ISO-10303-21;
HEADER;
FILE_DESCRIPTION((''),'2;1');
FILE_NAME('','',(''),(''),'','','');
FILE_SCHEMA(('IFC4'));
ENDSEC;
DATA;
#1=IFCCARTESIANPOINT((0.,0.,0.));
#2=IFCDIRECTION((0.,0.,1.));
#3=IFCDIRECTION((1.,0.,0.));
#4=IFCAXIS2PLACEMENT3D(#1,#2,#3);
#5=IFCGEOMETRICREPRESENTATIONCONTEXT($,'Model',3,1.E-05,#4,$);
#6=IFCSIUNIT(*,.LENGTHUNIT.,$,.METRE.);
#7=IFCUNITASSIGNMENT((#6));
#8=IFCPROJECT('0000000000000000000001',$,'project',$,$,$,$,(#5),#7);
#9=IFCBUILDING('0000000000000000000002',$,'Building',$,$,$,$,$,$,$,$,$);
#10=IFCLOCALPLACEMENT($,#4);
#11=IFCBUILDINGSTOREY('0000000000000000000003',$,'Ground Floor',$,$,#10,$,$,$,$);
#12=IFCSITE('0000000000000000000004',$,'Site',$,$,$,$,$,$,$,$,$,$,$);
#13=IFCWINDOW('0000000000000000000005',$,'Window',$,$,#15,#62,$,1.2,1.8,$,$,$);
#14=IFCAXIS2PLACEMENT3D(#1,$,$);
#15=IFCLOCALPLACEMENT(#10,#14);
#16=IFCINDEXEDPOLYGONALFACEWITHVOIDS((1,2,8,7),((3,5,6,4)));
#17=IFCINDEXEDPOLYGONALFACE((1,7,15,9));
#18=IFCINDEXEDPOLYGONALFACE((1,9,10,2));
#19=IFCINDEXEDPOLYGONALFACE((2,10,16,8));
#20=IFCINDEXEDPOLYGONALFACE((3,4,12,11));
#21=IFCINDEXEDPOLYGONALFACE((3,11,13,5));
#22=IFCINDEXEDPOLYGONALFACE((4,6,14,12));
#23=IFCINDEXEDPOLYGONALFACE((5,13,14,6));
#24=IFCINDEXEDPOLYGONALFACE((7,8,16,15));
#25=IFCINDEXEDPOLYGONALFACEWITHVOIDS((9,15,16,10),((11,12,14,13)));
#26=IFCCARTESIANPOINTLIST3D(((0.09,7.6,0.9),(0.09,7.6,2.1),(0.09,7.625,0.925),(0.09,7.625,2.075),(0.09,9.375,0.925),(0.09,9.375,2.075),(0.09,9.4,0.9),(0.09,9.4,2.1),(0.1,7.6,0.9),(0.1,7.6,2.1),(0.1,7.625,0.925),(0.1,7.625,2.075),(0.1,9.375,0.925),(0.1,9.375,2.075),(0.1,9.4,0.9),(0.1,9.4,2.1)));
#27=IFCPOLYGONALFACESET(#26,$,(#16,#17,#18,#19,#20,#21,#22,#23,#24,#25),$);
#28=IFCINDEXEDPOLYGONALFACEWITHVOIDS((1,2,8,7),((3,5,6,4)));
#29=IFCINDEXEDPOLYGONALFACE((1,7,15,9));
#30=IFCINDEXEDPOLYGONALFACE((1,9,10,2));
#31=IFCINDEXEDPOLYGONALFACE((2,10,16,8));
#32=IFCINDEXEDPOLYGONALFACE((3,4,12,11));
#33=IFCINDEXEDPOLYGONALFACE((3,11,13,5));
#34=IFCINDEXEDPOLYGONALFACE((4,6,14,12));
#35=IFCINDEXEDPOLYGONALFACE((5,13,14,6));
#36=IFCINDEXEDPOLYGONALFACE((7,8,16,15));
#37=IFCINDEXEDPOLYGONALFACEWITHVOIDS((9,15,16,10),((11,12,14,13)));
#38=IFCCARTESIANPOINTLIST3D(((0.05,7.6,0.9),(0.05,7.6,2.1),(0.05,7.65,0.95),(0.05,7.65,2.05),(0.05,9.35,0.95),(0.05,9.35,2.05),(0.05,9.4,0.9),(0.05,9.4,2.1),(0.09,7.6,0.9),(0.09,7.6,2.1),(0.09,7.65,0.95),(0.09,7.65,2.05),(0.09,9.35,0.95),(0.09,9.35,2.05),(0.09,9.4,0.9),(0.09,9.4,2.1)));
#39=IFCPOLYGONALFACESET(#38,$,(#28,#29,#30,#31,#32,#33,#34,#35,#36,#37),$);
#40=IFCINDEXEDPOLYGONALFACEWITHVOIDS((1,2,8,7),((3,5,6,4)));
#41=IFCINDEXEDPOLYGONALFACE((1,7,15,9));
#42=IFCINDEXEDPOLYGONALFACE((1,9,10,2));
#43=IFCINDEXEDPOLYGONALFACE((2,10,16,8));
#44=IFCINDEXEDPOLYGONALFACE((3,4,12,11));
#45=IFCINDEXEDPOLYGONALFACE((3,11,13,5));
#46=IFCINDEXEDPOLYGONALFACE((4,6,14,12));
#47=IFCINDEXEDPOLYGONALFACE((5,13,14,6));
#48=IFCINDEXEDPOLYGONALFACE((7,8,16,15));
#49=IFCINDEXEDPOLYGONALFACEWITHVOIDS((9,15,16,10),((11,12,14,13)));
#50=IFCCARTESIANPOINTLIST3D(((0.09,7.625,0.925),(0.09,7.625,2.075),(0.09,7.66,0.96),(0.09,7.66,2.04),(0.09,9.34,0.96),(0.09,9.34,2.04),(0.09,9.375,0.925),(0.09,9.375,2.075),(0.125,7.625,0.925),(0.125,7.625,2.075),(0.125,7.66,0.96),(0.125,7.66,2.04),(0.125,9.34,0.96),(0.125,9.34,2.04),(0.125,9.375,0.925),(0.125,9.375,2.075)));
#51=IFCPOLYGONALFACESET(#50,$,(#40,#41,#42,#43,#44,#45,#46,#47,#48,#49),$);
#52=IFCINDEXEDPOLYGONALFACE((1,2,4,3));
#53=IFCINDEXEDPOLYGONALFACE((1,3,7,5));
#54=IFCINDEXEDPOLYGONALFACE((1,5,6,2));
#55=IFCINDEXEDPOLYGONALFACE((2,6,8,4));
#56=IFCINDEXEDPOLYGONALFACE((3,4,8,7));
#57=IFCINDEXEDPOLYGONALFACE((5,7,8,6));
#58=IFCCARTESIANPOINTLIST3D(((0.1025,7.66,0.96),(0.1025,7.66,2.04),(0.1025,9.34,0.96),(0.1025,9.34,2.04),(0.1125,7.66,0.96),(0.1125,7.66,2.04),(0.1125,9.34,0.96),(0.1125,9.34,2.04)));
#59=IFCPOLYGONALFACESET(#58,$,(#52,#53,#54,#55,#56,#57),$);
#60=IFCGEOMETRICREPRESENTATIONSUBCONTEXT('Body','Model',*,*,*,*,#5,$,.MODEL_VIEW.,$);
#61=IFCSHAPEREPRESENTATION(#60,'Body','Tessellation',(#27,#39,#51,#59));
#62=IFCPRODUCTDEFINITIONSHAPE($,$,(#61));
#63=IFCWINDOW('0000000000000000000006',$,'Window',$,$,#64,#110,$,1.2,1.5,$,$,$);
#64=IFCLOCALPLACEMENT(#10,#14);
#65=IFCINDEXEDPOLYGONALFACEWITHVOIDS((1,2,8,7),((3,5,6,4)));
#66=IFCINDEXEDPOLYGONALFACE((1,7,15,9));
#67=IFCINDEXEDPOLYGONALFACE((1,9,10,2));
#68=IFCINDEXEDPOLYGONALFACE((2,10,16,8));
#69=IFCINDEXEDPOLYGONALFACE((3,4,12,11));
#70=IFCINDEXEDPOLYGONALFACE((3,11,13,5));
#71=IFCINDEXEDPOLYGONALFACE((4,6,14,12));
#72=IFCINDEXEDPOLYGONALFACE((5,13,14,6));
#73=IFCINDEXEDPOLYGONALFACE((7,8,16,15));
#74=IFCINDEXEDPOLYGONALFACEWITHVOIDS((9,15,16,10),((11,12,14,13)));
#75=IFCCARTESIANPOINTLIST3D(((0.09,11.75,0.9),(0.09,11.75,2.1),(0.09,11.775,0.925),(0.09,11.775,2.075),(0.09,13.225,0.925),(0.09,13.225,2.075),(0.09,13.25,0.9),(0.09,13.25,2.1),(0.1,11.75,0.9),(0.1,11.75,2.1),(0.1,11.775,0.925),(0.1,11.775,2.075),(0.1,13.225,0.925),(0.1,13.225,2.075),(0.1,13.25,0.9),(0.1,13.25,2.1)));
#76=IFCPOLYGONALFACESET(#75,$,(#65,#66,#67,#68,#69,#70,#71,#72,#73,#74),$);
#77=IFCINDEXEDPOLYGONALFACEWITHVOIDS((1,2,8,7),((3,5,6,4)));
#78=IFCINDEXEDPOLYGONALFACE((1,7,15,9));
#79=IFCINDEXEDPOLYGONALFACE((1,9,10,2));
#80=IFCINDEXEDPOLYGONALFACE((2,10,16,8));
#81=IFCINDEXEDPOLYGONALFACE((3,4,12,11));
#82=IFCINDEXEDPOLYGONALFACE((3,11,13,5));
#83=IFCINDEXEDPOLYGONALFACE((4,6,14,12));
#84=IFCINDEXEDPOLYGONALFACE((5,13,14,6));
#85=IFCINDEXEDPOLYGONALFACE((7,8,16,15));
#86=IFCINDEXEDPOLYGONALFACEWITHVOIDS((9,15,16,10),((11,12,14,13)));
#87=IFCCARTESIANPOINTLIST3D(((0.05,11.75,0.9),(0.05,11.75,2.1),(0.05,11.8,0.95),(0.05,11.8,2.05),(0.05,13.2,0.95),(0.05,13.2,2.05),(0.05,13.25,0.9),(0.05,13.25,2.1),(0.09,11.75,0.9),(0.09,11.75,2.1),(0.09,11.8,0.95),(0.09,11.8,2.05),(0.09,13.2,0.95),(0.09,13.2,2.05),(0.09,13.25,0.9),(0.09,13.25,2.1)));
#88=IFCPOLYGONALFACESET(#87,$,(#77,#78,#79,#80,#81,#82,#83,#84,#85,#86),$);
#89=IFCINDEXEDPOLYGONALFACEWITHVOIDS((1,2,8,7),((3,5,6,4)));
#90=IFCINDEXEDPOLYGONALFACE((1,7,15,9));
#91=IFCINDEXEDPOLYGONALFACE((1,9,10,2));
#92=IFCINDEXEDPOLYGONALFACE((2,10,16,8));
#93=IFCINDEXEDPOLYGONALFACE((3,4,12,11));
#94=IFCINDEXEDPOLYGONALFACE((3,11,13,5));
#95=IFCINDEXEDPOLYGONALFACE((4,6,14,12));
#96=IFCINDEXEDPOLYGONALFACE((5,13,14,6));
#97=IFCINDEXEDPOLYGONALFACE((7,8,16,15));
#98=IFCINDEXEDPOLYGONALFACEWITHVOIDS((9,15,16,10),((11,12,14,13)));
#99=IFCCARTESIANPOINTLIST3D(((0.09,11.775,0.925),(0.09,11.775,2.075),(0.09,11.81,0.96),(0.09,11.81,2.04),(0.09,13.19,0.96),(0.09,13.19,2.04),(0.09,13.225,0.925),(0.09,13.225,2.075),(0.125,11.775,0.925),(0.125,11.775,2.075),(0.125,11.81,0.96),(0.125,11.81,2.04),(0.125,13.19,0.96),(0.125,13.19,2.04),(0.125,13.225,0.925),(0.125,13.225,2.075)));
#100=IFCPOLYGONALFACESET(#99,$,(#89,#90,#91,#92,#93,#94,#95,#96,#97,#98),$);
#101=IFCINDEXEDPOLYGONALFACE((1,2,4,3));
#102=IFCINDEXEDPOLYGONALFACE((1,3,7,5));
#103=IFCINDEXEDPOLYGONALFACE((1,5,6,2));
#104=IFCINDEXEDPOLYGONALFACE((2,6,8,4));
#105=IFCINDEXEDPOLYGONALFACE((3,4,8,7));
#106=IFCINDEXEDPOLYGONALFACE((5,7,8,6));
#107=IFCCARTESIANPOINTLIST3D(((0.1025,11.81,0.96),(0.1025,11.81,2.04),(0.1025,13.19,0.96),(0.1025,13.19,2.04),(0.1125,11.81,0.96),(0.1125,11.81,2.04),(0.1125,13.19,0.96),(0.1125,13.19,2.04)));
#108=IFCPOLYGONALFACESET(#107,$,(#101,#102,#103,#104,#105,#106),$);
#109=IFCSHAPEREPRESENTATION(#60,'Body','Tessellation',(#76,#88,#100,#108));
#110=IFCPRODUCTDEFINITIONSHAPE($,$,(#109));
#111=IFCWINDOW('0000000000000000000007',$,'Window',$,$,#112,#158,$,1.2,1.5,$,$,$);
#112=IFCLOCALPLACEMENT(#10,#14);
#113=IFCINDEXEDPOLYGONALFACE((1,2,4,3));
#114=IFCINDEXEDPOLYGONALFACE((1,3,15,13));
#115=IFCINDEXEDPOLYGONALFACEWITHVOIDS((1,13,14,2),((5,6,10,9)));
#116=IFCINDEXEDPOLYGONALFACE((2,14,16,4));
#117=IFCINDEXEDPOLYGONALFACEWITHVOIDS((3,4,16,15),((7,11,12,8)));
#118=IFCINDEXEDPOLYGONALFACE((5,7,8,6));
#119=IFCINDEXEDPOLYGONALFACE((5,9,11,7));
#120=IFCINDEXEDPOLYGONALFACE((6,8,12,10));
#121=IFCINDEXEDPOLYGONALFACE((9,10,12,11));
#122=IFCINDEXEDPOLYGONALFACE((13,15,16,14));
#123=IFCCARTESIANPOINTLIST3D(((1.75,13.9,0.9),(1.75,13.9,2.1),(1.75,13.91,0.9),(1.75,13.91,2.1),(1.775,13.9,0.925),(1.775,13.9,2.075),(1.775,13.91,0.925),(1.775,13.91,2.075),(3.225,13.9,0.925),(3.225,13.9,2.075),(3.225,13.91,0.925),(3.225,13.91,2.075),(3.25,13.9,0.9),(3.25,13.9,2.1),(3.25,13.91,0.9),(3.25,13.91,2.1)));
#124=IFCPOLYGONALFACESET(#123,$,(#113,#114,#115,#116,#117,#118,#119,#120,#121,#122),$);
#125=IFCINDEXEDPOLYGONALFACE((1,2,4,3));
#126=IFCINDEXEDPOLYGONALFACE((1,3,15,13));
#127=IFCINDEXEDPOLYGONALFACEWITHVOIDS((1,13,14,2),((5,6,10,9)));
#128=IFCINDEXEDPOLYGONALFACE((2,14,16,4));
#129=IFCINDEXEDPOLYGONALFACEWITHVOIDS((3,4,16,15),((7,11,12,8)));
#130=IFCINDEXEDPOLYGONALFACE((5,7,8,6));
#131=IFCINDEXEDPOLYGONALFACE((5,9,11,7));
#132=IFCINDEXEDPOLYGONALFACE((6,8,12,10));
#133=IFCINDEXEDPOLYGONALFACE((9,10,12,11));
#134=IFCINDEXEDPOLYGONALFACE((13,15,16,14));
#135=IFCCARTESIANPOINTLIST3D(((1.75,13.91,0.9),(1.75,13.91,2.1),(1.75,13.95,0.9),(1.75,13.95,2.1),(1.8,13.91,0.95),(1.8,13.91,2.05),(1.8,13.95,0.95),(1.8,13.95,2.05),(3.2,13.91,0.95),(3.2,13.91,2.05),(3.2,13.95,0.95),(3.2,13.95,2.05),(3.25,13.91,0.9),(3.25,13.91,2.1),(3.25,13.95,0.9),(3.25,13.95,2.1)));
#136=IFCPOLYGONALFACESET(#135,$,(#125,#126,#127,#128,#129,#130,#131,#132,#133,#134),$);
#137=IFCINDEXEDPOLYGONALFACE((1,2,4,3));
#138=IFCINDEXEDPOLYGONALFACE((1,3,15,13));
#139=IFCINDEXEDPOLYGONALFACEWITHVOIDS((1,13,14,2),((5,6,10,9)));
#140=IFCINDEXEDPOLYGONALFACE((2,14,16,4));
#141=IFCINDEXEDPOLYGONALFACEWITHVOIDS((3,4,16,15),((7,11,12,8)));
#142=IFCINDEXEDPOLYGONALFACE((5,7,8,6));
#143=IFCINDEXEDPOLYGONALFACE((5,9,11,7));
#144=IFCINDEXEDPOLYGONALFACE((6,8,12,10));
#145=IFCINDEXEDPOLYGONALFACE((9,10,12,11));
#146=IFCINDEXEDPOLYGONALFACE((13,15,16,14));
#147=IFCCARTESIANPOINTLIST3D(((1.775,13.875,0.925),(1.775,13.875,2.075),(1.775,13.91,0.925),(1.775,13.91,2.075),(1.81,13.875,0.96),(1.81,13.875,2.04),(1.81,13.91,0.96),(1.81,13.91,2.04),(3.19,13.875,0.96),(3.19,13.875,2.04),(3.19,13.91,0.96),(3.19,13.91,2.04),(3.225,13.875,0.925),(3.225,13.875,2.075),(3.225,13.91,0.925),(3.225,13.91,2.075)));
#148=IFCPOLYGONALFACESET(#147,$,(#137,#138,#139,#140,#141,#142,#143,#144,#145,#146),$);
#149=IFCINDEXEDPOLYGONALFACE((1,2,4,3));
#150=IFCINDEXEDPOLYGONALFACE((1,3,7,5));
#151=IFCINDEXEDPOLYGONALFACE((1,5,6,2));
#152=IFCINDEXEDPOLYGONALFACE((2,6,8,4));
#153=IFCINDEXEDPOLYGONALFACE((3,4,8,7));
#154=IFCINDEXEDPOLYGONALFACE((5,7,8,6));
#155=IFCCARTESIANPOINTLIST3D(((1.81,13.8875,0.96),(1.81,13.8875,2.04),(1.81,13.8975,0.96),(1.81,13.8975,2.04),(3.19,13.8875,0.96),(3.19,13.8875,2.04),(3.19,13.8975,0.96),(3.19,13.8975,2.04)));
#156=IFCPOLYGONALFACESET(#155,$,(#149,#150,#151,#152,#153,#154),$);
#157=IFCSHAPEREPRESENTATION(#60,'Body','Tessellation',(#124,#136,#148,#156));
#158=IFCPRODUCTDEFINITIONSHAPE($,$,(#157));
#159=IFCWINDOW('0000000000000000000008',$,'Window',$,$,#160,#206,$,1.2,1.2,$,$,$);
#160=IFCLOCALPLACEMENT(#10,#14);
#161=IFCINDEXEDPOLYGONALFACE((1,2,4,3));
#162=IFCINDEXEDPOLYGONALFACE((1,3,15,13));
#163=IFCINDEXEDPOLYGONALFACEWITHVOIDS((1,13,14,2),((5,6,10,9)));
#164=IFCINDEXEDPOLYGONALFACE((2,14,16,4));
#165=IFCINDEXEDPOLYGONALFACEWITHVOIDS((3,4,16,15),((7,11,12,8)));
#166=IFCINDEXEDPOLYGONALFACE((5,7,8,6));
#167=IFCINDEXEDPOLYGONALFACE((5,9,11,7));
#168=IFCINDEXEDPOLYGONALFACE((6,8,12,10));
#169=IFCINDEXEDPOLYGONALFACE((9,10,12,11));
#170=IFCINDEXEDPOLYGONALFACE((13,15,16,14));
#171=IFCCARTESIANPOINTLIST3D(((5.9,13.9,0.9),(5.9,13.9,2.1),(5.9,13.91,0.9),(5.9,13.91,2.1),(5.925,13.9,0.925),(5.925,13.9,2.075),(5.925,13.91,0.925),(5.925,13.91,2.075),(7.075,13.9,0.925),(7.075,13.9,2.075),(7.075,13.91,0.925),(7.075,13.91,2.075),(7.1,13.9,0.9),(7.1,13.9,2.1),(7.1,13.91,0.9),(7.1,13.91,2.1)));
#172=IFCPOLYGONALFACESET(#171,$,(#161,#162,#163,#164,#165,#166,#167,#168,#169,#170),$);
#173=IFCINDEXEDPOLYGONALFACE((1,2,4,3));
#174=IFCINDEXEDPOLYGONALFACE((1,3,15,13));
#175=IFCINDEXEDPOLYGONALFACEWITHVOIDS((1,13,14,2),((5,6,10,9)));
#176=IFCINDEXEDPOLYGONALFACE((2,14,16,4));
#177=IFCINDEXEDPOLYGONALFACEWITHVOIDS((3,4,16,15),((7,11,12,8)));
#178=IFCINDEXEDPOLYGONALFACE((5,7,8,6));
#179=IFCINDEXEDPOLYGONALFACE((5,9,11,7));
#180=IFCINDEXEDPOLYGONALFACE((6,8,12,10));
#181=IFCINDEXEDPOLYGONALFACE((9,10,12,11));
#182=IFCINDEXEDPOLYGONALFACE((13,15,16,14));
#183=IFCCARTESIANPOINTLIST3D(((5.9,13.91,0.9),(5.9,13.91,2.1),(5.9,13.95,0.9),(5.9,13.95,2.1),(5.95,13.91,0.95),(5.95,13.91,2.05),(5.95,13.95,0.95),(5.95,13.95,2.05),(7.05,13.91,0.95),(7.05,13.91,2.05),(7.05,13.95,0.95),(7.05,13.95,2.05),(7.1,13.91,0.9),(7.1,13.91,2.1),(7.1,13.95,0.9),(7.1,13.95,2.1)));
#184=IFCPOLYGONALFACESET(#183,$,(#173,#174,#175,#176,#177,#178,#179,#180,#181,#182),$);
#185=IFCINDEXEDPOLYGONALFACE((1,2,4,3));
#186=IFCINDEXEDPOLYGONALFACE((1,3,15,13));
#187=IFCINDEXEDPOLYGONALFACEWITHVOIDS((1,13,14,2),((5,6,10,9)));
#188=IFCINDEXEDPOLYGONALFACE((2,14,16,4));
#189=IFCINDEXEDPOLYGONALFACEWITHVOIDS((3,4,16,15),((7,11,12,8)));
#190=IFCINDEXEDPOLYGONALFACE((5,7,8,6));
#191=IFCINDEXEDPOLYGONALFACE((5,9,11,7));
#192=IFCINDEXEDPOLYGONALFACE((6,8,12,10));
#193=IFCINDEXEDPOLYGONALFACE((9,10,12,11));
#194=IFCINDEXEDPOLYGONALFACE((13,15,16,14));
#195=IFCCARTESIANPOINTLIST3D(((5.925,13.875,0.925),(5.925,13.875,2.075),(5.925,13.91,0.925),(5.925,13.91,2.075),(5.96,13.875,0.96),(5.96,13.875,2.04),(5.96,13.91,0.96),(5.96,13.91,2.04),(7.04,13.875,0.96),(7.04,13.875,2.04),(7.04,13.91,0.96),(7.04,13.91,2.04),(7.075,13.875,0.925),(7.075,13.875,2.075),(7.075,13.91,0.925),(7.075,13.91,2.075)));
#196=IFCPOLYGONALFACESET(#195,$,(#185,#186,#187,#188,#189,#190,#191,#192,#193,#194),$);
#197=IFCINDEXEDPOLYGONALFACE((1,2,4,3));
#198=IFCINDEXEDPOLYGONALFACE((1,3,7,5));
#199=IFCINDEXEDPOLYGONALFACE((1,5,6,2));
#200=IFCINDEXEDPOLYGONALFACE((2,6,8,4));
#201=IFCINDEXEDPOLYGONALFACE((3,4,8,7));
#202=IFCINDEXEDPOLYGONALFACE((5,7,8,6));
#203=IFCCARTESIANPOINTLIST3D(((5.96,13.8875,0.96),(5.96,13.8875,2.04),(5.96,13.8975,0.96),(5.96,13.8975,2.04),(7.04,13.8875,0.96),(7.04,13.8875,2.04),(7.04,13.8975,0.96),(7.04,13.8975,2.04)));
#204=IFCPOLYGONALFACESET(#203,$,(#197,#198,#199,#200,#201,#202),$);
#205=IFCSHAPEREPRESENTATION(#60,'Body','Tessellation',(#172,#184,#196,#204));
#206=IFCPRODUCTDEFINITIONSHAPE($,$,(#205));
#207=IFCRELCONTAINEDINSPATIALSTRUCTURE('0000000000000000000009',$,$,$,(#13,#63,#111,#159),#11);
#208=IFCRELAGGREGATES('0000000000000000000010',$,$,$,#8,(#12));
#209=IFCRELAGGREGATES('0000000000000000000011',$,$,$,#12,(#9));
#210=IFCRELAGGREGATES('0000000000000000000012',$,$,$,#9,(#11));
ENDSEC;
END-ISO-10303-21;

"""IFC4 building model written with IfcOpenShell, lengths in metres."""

from ifc_helpers import new_model, si_unit, frame, origin_with_axes, place, context, subcontext, project, spatial, line, indexed_curve, outline, extrude, element, save


model = new_model("IFC4")

# Units and contexts
model_context = context("Model", 3, precision=1e-05, world=origin_with_axes())
body_context = subcontext(model_context, "Body", "Model", "MODEL_VIEW")
ifc_project = project(units=[si_unit("LENGTHUNIT", "METRE")], contexts=[model_context])

# Site, building, storey
site = spatial("IfcSite", under=ifc_project, Name="Site")
building = spatial("IfcBuilding", under=site, Name="Building")
storey_placement = place(None, origin_with_axes())
storey = spatial("IfcBuildingStorey", under=building, at=storey_placement, Name="Ground Floor")

# Windows
window_1_placement = place(storey_placement, frame((0.0, 9.4, 0.9), z_axis=(0.0, 0.0, 1.0), x_axis=(0.0, -1.0, 0.0)))
element("IfcWindow", 1, at=window_1_placement, inside=storey, Name="Window", OverallHeight=1.2, OverallWidth=1.8, context=body_context, shape_type="SweptSolid", body=[
    extrude(outline(indexed_curve([(0.0, 0.0), (1.8, 0.0), (1.8, 1.2), (0.0, 1.2)], segments=[line(1, 2, 3, 4, 1)]), holes=[indexed_curve([(0.025, 0.025), (1.775, 0.025), (1.775, 1.175), (0.025, 1.175)], segments=[line(1, 2, 3, 4, 1)])]), frame((0.0, 0.09, 0.0), z_axis=(0.0, -1.0, 0.0), x_axis=(1.0, 0.0, 0.0)), (0.0, 0.0, -1.0), 0.01),
    extrude(outline(indexed_curve([(0.0, 0.0), (1.8, 0.0), (1.8, 1.2), (0.0, 1.2)], segments=[line(1, 2, 3, 4, 1)]), holes=[indexed_curve([(0.05, 0.05), (1.75, 0.05), (1.75, 1.15), (0.05, 1.15)], segments=[line(1, 2, 3, 4, 1)])]), frame((0.0, 0.05, 0.0), z_axis=(0.0, -1.0, 0.0), x_axis=(1.0, 0.0, 0.0)), (0.0, 0.0, -1.0), 0.04),
    extrude(outline(indexed_curve([(0.0, 0.0), (1.75, 0.0), (1.75, 1.15), (0.0, 1.15)], segments=[line(1, 2, 3, 4, 1)]), holes=[indexed_curve([(0.035, 0.035), (1.715, 0.035), (1.715, 1.115), (0.035, 1.115)], segments=[line(1, 2, 3, 4, 1)])]), frame((0.025, 0.09, 0.025), z_axis=(0.0, -1.0, 0.0), x_axis=(1.0, 0.0, 0.0)), (0.0, 0.0, -1.0), 0.035),
    extrude(outline(indexed_curve([(0.035, 0.035), (1.715, 0.035), (1.715, 1.115), (0.035, 1.115)], segments=[line(1, 2, 3, 4, 1)])), frame((0.025, 0.1025, 0.025), z_axis=(0.0, -1.0, 0.0), x_axis=(1.0, 0.0, 0.0)), (0.0, 0.0, -1.0), 0.01),
])
for number, where, z_axis, x_axis, name in (
    (2, (0.0, 13.25, 0.9), (0.0, 0.0, 1.0), (0.0, -1.0, 0.0), "Window"),
    (3, (3.25, 14.0, 0.9), (0.0, 0.0, 1.0), (-1.0, 0.0, 0.0), "Window"),
):
    element("IfcWindow", number, at=place(storey_placement, frame(where, z_axis=z_axis, x_axis=x_axis)), inside=storey, Name=name, OverallHeight=1.2, OverallWidth=1.5, context=body_context, shape_type="SweptSolid", body=[
        extrude(outline(indexed_curve([(0.0, 0.0), (1.5, 0.0), (1.5, 1.2), (0.0, 1.2)], segments=[line(1, 2, 3, 4, 1)]), holes=[indexed_curve([(0.025, 0.025), (1.475, 0.025), (1.475, 1.175), (0.025, 1.175)], segments=[line(1, 2, 3, 4, 1)])]), frame((0.0, 0.09, 0.0), z_axis=(0.0, -1.0, 0.0), x_axis=(1.0, 0.0, 0.0)), (0.0, 0.0, -1.0), 0.01),
        extrude(outline(indexed_curve([(0.0, 0.0), (1.5, 0.0), (1.5, 1.2), (0.0, 1.2)], segments=[line(1, 2, 3, 4, 1)]), holes=[indexed_curve([(0.05, 0.05), (1.45, 0.05), (1.45, 1.15), (0.05, 1.15)], segments=[line(1, 2, 3, 4, 1)])]), frame((0.0, 0.05, 0.0), z_axis=(0.0, -1.0, 0.0), x_axis=(1.0, 0.0, 0.0)), (0.0, 0.0, -1.0), 0.04),
        extrude(outline(indexed_curve([(0.0, 0.0), (1.45, 0.0), (1.45, 1.15), (0.0, 1.15)], segments=[line(1, 2, 3, 4, 1)]), holes=[indexed_curve([(0.035, 0.035), (1.415, 0.035), (1.415, 1.115), (0.035, 1.115)], segments=[line(1, 2, 3, 4, 1)])]), frame((0.025, 0.09, 0.025), z_axis=(0.0, -1.0, 0.0), x_axis=(1.0, 0.0, 0.0)), (0.0, 0.0, -1.0), 0.035),
        extrude(outline(indexed_curve([(0.035, 0.035), (1.415, 0.035), (1.415, 1.115), (0.035, 1.115)], segments=[line(1, 2, 3, 4, 1)])), frame((0.025, 0.1025, 0.025), z_axis=(0.0, -1.0, 0.0), x_axis=(1.0, 0.0, 0.0)), (0.0, 0.0, -1.0), 0.01),
    ])
window_2_placement = place(storey_placement, frame((7.1, 14.0, 0.9), z_axis=(0.0, 0.0, 1.0), x_axis=(-1.0, 0.0, 0.0)))
element("IfcWindow", 4, at=window_2_placement, inside=storey, Name="Window", OverallHeight=1.2, OverallWidth=1.2, context=body_context, shape_type="SweptSolid", body=[
    extrude(outline(indexed_curve([(0.0, 0.0), (1.2, 0.0), (1.2, 1.2), (0.0, 1.2)], segments=[line(1, 2, 3, 4, 1)]), holes=[indexed_curve([(0.025, 0.025), (1.175, 0.025), (1.175, 1.175), (0.025, 1.175)], segments=[line(1, 2, 3, 4, 1)])]), frame((0.0, 0.09, 0.0), z_axis=(0.0, -1.0, 0.0), x_axis=(1.0, 0.0, 0.0)), (0.0, 0.0, -1.0), 0.01),
    extrude(outline(indexed_curve([(0.0, 0.0), (1.2, 0.0), (1.2, 1.2), (0.0, 1.2)], segments=[line(1, 2, 3, 4, 1)]), holes=[indexed_curve([(0.05, 0.05), (1.15, 0.05), (1.15, 1.15), (0.05, 1.15)], segments=[line(1, 2, 3, 4, 1)])]), frame((0.0, 0.05, 0.0), z_axis=(0.0, -1.0, 0.0), x_axis=(1.0, 0.0, 0.0)), (0.0, 0.0, -1.0), 0.04),
    extrude(outline(indexed_curve([(0.0, 0.0), (1.15, 0.0), (1.15, 1.15), (0.0, 1.15)], segments=[line(1, 2, 3, 4, 1)]), holes=[indexed_curve([(0.035, 0.035), (1.115, 0.035), (1.115, 1.115), (0.035, 1.115)], segments=[line(1, 2, 3, 4, 1)])]), frame((0.025, 0.09, 0.025), z_axis=(0.0, -1.0, 0.0), x_axis=(1.0, 0.0, 0.0)), (0.0, 0.0, -1.0), 0.035),
    extrude(outline(indexed_curve([(0.035, 0.035), (1.115, 0.035), (1.115, 1.115), (0.035, 1.115)], segments=[line(1, 2, 3, 4, 1)])), frame((0.025, 0.1025, 0.025), z_axis=(0.0, -1.0, 0.0), x_axis=(1.0, 0.0, 0.0)), (0.0, 0.0, -1.0), 0.01),
])

save(model, "model.ifc")
